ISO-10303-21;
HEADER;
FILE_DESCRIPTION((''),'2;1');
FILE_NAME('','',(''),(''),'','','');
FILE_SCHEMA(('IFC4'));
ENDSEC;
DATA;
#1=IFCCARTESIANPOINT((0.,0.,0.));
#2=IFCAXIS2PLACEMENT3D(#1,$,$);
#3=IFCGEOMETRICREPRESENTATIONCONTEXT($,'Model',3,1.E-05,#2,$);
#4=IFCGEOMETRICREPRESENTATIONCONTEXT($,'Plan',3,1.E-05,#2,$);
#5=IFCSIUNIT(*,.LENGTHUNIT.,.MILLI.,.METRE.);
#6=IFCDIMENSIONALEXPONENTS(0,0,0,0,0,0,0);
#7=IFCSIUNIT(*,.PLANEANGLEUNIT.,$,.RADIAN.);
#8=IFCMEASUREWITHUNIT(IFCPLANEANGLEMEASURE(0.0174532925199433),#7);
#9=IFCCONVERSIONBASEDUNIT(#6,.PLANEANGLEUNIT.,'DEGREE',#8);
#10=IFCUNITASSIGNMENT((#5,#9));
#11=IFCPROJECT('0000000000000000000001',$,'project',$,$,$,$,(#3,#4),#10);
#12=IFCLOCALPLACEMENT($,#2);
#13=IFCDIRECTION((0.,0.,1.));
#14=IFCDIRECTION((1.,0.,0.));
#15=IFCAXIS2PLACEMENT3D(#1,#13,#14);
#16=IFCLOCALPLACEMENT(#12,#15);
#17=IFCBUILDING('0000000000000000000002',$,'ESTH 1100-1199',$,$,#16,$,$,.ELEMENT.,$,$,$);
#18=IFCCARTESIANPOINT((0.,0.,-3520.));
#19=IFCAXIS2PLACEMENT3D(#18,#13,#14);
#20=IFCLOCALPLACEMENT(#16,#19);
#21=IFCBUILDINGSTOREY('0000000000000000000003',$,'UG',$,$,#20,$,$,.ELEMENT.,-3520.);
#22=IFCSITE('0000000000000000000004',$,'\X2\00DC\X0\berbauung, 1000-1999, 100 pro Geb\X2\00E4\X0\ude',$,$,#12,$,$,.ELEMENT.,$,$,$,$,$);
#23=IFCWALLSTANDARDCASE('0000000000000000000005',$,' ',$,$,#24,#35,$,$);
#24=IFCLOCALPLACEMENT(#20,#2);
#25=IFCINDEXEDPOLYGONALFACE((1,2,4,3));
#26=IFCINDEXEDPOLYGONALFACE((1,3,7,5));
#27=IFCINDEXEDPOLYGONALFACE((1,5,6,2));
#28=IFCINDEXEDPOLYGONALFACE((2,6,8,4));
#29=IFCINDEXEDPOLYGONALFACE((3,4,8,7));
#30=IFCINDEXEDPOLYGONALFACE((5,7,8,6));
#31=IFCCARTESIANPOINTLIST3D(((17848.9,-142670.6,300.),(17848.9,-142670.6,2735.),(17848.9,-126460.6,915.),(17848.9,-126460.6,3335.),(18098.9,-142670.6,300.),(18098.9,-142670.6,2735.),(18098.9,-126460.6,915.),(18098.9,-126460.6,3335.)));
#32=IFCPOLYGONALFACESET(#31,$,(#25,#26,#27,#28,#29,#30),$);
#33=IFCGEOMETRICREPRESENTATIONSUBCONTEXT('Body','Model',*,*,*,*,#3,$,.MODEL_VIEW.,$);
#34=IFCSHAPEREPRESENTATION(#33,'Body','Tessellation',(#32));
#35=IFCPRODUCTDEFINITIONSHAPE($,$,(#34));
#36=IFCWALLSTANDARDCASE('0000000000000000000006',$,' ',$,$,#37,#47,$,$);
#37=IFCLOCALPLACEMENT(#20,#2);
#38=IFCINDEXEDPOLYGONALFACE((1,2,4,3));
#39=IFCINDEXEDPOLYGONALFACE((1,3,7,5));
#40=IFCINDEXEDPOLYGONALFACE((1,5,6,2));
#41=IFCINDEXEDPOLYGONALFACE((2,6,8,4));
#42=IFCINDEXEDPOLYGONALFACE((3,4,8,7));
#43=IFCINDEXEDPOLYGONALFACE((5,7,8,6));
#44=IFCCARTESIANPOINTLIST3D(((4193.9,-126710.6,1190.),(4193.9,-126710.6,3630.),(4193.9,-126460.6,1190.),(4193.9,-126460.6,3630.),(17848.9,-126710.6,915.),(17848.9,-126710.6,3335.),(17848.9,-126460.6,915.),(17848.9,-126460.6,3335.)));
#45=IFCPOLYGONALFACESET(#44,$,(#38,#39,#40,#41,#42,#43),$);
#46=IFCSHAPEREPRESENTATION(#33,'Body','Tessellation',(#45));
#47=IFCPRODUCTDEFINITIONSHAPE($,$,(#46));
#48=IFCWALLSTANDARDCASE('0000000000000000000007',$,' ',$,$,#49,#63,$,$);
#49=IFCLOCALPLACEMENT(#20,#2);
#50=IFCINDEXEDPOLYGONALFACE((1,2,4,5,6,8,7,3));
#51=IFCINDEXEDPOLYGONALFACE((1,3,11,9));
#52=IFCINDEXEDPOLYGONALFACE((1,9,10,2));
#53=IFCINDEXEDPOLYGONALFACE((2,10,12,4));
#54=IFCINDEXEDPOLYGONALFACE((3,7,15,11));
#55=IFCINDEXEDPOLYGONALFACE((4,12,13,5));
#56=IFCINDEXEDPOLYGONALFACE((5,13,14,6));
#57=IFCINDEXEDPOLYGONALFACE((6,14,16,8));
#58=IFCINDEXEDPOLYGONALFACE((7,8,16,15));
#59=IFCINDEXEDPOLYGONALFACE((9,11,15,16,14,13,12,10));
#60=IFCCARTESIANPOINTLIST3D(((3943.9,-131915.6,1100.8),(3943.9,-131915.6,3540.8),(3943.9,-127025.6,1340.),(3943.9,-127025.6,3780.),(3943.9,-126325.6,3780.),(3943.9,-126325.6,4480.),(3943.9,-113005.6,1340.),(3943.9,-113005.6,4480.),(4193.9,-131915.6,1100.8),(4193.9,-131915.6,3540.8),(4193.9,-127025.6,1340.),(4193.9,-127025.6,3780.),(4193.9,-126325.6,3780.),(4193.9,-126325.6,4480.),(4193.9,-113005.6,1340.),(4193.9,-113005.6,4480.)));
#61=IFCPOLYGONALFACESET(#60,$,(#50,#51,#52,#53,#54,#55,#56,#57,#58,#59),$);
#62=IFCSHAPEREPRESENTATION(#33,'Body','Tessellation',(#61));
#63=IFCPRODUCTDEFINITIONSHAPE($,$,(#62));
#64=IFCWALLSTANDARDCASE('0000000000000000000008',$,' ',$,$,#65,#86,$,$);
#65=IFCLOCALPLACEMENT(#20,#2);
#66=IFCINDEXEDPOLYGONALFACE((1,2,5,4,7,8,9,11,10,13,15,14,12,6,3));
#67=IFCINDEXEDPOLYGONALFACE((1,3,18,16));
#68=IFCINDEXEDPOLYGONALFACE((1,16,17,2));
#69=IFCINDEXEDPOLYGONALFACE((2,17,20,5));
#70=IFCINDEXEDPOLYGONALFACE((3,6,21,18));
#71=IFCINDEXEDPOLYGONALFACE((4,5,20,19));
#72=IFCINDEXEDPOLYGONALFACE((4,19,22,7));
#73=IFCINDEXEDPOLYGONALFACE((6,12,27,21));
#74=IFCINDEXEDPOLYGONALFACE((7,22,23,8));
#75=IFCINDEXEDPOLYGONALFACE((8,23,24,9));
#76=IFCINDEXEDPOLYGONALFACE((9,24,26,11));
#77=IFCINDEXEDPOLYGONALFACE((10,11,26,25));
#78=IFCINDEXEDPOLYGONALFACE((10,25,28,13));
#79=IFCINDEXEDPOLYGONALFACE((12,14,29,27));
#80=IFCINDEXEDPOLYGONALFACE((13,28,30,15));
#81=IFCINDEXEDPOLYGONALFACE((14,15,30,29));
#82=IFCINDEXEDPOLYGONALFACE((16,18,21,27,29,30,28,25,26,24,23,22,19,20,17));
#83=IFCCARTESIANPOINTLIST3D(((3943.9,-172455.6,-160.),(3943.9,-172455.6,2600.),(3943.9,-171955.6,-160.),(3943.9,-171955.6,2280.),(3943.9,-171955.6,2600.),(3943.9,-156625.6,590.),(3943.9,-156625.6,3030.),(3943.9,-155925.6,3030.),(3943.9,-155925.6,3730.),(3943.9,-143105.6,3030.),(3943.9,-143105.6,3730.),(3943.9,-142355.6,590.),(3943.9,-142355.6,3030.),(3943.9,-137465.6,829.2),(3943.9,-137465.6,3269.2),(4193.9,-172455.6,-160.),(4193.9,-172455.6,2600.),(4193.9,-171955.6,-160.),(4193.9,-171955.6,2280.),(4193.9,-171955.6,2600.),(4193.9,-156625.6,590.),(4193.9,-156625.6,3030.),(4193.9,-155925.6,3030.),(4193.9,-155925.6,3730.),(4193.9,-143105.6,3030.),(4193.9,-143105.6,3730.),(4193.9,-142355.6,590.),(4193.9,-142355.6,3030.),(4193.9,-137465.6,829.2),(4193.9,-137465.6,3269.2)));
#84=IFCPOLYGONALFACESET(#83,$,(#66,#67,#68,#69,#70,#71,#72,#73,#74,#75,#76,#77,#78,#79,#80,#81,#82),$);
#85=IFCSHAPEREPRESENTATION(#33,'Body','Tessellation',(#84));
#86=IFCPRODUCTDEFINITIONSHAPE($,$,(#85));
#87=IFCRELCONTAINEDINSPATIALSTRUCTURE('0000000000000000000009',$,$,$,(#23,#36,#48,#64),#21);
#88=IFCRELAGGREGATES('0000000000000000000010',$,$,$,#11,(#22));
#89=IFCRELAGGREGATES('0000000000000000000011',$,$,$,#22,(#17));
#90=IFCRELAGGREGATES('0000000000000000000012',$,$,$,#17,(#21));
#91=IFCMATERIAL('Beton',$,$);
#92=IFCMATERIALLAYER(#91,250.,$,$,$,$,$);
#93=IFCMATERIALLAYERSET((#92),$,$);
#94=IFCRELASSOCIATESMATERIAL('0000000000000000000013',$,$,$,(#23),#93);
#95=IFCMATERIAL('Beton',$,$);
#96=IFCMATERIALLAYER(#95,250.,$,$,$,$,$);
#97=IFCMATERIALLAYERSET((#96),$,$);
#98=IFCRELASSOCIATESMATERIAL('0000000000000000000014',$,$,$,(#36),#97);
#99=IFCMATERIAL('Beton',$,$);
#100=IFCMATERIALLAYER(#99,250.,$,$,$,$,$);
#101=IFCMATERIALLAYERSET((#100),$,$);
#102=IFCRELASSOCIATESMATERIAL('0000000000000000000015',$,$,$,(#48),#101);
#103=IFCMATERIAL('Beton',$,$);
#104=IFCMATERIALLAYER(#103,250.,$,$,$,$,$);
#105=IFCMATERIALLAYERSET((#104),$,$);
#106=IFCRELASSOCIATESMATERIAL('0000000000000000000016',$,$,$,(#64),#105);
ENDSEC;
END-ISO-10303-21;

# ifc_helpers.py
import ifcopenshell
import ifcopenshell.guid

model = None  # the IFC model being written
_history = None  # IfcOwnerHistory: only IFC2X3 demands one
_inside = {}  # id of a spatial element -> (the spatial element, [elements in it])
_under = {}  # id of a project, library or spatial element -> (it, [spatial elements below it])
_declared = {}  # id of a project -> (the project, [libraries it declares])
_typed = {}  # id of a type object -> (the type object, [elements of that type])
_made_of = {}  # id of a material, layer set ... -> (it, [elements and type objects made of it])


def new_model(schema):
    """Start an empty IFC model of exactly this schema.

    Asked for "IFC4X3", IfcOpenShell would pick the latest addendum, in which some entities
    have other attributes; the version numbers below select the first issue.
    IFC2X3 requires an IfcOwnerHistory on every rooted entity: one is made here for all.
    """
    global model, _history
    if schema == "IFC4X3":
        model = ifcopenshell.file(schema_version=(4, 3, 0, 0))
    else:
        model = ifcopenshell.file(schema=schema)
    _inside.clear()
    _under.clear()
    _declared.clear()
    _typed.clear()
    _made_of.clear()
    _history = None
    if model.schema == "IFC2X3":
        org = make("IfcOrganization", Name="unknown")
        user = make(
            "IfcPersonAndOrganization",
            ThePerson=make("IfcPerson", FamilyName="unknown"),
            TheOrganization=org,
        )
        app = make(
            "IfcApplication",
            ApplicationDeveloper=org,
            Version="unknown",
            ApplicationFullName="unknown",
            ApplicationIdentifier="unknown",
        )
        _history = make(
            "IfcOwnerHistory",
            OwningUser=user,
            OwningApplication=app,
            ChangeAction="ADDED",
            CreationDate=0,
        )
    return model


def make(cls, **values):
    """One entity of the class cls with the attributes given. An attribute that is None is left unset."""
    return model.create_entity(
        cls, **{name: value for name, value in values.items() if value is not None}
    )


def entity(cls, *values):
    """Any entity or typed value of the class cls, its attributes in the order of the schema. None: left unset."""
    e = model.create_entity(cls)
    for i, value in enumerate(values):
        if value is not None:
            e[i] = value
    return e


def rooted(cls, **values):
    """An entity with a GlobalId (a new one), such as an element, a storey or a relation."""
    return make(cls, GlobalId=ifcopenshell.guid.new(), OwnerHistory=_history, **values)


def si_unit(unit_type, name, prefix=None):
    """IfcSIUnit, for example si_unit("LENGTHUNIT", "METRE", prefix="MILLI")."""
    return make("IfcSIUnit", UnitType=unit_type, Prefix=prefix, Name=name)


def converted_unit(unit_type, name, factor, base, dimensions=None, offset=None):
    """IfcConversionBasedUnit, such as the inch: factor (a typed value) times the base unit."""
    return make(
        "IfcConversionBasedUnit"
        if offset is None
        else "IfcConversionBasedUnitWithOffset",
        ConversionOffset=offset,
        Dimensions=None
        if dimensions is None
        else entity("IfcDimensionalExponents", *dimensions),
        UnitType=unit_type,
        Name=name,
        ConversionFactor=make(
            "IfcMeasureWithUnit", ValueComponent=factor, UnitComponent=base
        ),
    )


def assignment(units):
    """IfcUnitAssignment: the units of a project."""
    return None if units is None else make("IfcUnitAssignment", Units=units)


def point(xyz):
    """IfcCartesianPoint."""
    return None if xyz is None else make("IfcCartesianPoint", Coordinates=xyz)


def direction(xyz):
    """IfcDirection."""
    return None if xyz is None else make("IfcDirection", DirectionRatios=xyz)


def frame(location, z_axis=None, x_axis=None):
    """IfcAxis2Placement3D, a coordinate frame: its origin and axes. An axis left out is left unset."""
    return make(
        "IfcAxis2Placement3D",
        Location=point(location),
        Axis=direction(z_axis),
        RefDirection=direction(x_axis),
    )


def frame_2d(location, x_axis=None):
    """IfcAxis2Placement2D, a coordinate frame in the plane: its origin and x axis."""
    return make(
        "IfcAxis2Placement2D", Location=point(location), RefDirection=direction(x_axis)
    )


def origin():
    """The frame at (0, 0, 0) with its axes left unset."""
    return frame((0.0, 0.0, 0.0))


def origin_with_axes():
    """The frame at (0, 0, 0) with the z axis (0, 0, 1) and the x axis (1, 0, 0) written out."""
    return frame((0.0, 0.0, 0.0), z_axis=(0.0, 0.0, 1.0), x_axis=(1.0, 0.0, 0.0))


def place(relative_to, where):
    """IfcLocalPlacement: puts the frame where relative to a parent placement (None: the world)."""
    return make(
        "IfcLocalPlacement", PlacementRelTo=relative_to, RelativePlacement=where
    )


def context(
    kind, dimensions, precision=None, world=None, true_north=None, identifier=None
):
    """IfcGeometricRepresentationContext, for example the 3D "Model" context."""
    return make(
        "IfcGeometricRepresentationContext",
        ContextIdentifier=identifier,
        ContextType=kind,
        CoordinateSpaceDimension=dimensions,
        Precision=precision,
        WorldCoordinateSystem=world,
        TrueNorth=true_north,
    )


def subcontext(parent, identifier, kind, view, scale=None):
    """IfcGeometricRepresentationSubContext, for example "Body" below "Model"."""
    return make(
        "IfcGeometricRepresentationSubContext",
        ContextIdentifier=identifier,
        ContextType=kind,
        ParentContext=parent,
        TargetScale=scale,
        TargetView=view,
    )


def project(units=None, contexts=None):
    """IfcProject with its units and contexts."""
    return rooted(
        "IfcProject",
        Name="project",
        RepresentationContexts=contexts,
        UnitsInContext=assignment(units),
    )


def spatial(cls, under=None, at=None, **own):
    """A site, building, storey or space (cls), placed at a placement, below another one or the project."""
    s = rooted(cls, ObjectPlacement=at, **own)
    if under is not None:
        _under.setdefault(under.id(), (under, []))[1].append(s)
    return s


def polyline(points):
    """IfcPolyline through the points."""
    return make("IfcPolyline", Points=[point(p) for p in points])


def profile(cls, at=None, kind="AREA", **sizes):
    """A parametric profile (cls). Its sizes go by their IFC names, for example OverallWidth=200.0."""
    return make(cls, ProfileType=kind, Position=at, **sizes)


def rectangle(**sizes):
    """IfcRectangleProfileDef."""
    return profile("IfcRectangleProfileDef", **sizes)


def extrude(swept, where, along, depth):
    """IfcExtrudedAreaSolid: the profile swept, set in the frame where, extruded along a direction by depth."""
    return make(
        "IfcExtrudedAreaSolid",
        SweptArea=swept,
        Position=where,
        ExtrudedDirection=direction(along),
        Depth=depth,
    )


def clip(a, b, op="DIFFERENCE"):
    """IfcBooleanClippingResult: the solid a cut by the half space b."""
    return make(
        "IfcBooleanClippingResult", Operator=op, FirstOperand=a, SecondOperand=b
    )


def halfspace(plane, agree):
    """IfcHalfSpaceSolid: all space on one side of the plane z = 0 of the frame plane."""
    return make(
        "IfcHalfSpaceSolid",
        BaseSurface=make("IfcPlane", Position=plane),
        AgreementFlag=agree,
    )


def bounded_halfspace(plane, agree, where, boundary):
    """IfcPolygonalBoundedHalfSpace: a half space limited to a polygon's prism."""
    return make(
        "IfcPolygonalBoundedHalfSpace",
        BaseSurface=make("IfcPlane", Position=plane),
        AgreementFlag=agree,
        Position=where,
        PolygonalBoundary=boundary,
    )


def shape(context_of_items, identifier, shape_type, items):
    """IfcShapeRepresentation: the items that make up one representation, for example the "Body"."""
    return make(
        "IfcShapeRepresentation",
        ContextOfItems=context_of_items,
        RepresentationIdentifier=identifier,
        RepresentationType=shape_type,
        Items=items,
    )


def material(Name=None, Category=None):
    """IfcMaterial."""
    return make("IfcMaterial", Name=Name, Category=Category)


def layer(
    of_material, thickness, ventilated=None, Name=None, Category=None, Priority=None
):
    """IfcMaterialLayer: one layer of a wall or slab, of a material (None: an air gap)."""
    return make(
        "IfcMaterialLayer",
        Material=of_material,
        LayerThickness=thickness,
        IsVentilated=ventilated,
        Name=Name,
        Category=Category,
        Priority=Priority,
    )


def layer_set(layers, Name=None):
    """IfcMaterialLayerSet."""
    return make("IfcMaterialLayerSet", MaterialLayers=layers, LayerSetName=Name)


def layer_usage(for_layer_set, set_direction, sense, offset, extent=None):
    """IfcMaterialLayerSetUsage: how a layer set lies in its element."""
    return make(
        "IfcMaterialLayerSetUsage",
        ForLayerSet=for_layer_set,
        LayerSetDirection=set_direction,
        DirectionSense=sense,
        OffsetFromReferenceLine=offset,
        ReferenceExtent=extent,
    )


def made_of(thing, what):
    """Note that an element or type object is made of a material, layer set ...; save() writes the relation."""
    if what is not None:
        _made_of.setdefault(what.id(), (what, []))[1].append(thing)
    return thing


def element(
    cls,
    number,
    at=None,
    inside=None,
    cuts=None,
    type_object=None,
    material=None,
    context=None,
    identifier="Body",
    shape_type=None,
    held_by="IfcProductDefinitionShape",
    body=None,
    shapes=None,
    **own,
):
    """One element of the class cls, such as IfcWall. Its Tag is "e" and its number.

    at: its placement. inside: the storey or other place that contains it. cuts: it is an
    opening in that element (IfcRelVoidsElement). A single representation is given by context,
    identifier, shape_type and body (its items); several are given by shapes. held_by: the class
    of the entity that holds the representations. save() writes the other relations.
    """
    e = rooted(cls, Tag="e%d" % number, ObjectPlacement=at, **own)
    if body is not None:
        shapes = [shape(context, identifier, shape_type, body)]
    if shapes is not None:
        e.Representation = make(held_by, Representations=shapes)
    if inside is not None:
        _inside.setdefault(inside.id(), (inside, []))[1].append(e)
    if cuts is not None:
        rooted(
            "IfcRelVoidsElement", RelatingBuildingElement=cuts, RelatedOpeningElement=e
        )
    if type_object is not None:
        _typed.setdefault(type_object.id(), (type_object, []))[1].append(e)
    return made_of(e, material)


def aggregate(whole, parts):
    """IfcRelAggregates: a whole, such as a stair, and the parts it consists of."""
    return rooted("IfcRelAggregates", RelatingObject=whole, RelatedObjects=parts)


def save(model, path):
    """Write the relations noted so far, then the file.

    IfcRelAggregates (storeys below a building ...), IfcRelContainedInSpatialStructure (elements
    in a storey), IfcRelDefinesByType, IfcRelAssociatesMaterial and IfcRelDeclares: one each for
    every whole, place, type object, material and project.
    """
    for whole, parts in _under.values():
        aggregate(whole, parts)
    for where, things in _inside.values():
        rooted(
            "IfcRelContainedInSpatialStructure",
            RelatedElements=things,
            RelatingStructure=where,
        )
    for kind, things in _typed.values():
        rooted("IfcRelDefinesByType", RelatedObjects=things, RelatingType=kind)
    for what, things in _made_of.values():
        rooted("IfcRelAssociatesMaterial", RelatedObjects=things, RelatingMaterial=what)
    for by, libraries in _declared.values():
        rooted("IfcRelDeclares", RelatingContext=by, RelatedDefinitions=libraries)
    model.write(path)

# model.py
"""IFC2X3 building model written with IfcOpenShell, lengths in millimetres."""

from ifc_helpers import new_model, entity, si_unit, converted_unit, frame, frame_2d, origin, origin_with_axes, place, context, subcontext, project, spatial, polyline, rectangle, extrude, clip, halfspace, bounded_halfspace, material, layer, layer_set, layer_usage, element, save


model = new_model("IFC2X3")

# Units and contexts
model_context = context("Model", 3, precision=1e-05, world=origin())
plan_context = context("Plan", 3, precision=1e-05, world=origin())
body_context = subcontext(model_context, "Body", "Model", "MODEL_VIEW")
ifc_project = project(units=[si_unit("LENGTHUNIT", "METRE", prefix="MILLI"), converted_unit("PLANEANGLEUNIT", "DEGREE", entity("IfcPlaneAngleMeasure", 0.0174532925199433), si_unit("PLANEANGLEUNIT", "RADIAN"), dimensions=[0, 0, 0, 0, 0, 0, 0])], contexts=[model_context, plan_context])

# Site, building, storey
site_placement = place(None, origin())
site = spatial("IfcSite", under=ifc_project, at=site_placement, Name="Überbauung, 1000-1999, 100 pro Gebäude", CompositionType="ELEMENT")
building_placement = place(site_placement, origin_with_axes())
building = spatial("IfcBuilding", under=site, at=building_placement, Name="ESTH 1100-1199", CompositionType="ELEMENT")
storey_placement = place(building_placement, frame((0.0, 0.0, -3520.0), z_axis=(0.0, 0.0, 1.0), x_axis=(1.0, 0.0, 0.0)))
storey = spatial("IfcBuildingStorey", under=building, at=storey_placement, Name="UG", CompositionType="ELEMENT", Elevation=-3520.0)

# Walls
ifc_material_1 = material(Name="Beton")
ifc_layer_1 = layer(ifc_material_1, 250.0)
ifc_layer_set_1 = layer_set([ifc_layer_1])
ifc_layer_usage_1 = layer_usage(ifc_layer_set_1, "AXIS2", "POSITIVE", 0.0)
wall_1_placement = place(storey_placement, frame((18098.9, -142670.6, 300.0), z_axis=(0.0, 0.0, 1.0), x_axis=(0.0, 1.0, 0.0)))
element("IfcWallStandardCase", 1, at=wall_1_placement, inside=storey, material=ifc_layer_usage_1, Name=" ", context=body_context, shape_type="Clipping", body=[
    clip(clip(extrude(rectangle(XDim=16210.0, YDim=250.0, at=frame_2d((8105.0, 125.0), x_axis=(1.0, 0.0))), origin_with_axes(), (0.0, 0.0, 1.0), 3035.0), halfspace(frame((0.0, 250.0, 0.0), z_axis=(-0.037912, 0.0, 0.999281), x_axis=(0.0, -1.0, 0.0)), True)), halfspace(frame((0.0, 0.0, 2435.0), z_axis=(0.036989, 0.0, -0.999316), x_axis=(0.999316, 0.0, 0.036989)), True)),
])
ifc_material_2 = material(Name="Beton")
ifc_layer_2 = layer(ifc_material_2, 250.0)
ifc_layer_set_2 = layer_set([ifc_layer_2])
ifc_layer_usage_2 = layer_usage(ifc_layer_set_2, "AXIS2", "POSITIVE", 0.0)
wall_2_placement = place(storey_placement, frame((17848.9, -126460.6, 915.0), z_axis=(0.0, 0.0, 1.0), x_axis=(-1.0, 0.0, 0.0)))
element("IfcWallStandardCase", 2, at=wall_2_placement, inside=storey, material=ifc_layer_usage_2, Name=" ", context=body_context, shape_type="Clipping", body=[
    clip(clip(extrude(rectangle(XDim=13655.0, YDim=250.0, at=frame_2d((6827.5, 125.0), x_axis=(1.0, 0.0))), origin_with_axes(), (0.0, 0.0, 1.0), 2715.0), halfspace(frame((0.0, 250.0, 0.0), z_axis=(-0.020135, 0.0, 0.999797), x_axis=(0.0, -1.0, 0.0)), True)), halfspace(frame((0.0, 0.0, 2420.0), z_axis=(0.021599, 0.0, -0.999767), x_axis=(0.999767, 0.0, 0.021599)), True)),
])
ifc_material_3 = material(Name="Beton")
ifc_layer_3 = layer(ifc_material_3, 250.0)
ifc_layer_set_3 = layer_set([ifc_layer_3])
ifc_layer_usage_3 = layer_usage(ifc_layer_set_3, "AXIS2", "POSITIVE", 0.0)
wall_3_placement = place(storey_placement, frame((4193.9, -131915.6, 1100.8), z_axis=(0.0, 0.0, 1.0), x_axis=(0.0, 1.0, 0.0)))
element("IfcWallStandardCase", 3, at=wall_3_placement, inside=storey, material=ifc_layer_usage_3, Name=" ", context=body_context, shape_type="Clipping", body=[
    clip(clip(clip(clip(clip(extrude(rectangle(XDim=18910.0, YDim=250.0, at=frame_2d((9455.0, 125.0), x_axis=(1.0, 0.0))), origin_with_axes(), (0.0, 0.0, 1.0), 3379.2), bounded_halfspace(frame((4890.0, 250.0, 239.2), z_axis=(0.0, 0.0, 1.0), x_axis=(0.0, -1.0, 0.0)), True, origin(), polyline([(4890.0, 250.0), (4890.0, 0.0), (18910.0, 0.0), (18910.0, 250.0), (4890.0, 250.0)]))), bounded_halfspace(frame((5590.0, 0.0, 3379.2), z_axis=(0.0, 0.0, -1.0), x_axis=(1.0, 0.0, 0.0)), True, origin(), polyline([(5590.0, 0.0), (18910.0, 0.0), (18910.0, 250.0), (5590.0, 250.0), (5590.0, 0.0)]))), bounded_halfspace(frame((4890.0, 0.0, 2679.2), z_axis=(0.0, 0.0, -1.0), x_axis=(1.0, 0.0, 0.0)), True, origin(), polyline([(4890.0, 0.0), (5590.0, 0.0), (5590.0, 250.0), (4890.0, 250.0), (4890.0, 0.0)]))), bounded_halfspace(frame((0.0, 250.0, 0.0), z_axis=(-0.048865, 0.0, 0.998805), x_axis=(0.0, -1.0, 0.0)), True, origin(), polyline([(0.0, 250.0), (0.0, 0.0), (4890.0, 0.0), (4890.0, 250.0), (0.0, 250.0)]))), bounded_halfspace(frame((0.0, 0.0, 2440.0), z_axis=(0.048865, 0.0, -0.998805), x_axis=(0.998805, 0.0, 0.048865)), True, origin(), polyline([(0.0, 0.0), (4890.0, 0.0), (4890.0, 250.0), (0.0, 250.0), (0.0, 0.0)]))),
])
ifc_material_4 = material(Name="Beton")
ifc_layer_4 = layer(ifc_material_4, 250.0)
ifc_layer_set_4 = layer_set([ifc_layer_4])
ifc_layer_usage_4 = layer_usage(ifc_layer_set_4, "AXIS2", "POSITIVE", 0.0)
wall_4_placement = place(storey_placement, frame((4193.9, -172455.6, -160.0), z_axis=(0.0, 0.0, 1.0), x_axis=(0.0, 1.0, 0.0)))
solid = clip(clip(clip(clip(clip(clip(clip(clip(extrude(rectangle(XDim=34990.0, YDim=250.0, at=frame_2d((17495.0, 125.0), x_axis=(1.0, 0.0))), origin_with_axes(), (0.0, 0.0, 1.0), 3890.0), bounded_halfspace(frame((30100.0, 250.0, 750.0), z_axis=(-0.048865, 0.0, 0.998805), x_axis=(0.0, -1.0, 0.0)), True, origin(), polyline([(30100.0, 250.0), (30100.0, 0.0), (34990.0, 0.0), (34990.0, 250.0), (30100.0, 250.0)]))), bounded_halfspace(frame((30100.0, 0.0, 3190.0), z_axis=(0.048865, 0.0, -0.998805), x_axis=(0.998805, 0.0, 0.048865)), True, origin(), polyline([(30100.0, 0.0), (34990.0, 0.0), (34990.0, 250.0), (30100.0, 250.0), (30100.0, 0.0)]))), bounded_halfspace(frame((15830.0, 250.0, 750.0), z_axis=(0.0, 0.0, 1.0), x_axis=(0.0, -1.0, 0.0)), True, origin(), polyline([(15830.0, 250.0), (15830.0, 0.0), (30100.0, 0.0), (30100.0, 250.0), (15830.0, 250.0)]))), bounded_halfspace(frame((29350.0, 0.0, 3190.0), z_axis=(0.0, 0.0, -1.0), x_axis=(1.0, 0.0, 0.0)), True, origin(), polyline([(29350.0, 0.0), (30100.0, 0.0), (30100.0, 250.0), (29350.0, 250.0), (29350.0, 0.0)]))), bounded_halfspace(frame((16530.0, 0.0, 3890.0), z_axis=(0.0, 0.0, -1.0), x_axis=(1.0, 0.0, 0.0)), True, origin(), polyline([(16530.0, 0.0), (29350.0, 0.0), (29350.0, 250.0), (16530.0, 250.0), (16530.0, 0.0)]))), bounded_halfspace(frame((15830.0, 0.0, 3190.0), z_axis=(0.0, 0.0, -1.0), x_axis=(1.0, 0.0, 0.0)), True, origin(), polyline([(15830.0, 0.0), (16530.0, 0.0), (16530.0, 250.0), (15830.0, 250.0), (15830.0, 0.0)]))), bounded_halfspace(frame((500.0, 250.0, 0.0), z_axis=(-0.048865, 0.0, 0.998805), x_axis=(0.0, -1.0, 0.0)), True, origin(), polyline([(500.0, 250.0), (500.0, 0.0), (15830.0, 0.0), (15830.0, 250.0), (500.0, 250.0)]))), bounded_halfspace(frame((500.0, 0.0, 2440.0), z_axis=(0.048865, 0.0, -0.998805), x_axis=(0.998805, 0.0, 0.048865)), True, origin(), polyline([(500.0, 0.0), (15830.0, 0.0), (15830.0, 250.0), (500.0, 250.0), (500.0, 0.0)])))
element("IfcWallStandardCase", 4, at=wall_4_placement, inside=storey, material=ifc_layer_usage_4, Name=" ", context=body_context, shape_type="Clipping", body=[
    clip(clip(solid, bounded_halfspace(frame((0.0, 250.0, 0.0), z_axis=(0.0, 0.0, 1.0), x_axis=(0.0, -1.0, 0.0)), True, origin(), polyline([(0.0, 250.0), (0.0, 0.0), (500.0, 0.0), (500.0, 250.0), (0.0, 250.0)]))), bounded_halfspace(frame((0.0, 0.0, 2760.0), z_axis=(0.0, 0.0, -1.0), x_axis=(1.0, 0.0, 0.0)), True, origin(), polyline([(0.0, 0.0), (500.0, 0.0), (500.0, 250.0), (0.0, 250.0), (0.0, 0.0)]))),
])

save(model, "model.ifc")
